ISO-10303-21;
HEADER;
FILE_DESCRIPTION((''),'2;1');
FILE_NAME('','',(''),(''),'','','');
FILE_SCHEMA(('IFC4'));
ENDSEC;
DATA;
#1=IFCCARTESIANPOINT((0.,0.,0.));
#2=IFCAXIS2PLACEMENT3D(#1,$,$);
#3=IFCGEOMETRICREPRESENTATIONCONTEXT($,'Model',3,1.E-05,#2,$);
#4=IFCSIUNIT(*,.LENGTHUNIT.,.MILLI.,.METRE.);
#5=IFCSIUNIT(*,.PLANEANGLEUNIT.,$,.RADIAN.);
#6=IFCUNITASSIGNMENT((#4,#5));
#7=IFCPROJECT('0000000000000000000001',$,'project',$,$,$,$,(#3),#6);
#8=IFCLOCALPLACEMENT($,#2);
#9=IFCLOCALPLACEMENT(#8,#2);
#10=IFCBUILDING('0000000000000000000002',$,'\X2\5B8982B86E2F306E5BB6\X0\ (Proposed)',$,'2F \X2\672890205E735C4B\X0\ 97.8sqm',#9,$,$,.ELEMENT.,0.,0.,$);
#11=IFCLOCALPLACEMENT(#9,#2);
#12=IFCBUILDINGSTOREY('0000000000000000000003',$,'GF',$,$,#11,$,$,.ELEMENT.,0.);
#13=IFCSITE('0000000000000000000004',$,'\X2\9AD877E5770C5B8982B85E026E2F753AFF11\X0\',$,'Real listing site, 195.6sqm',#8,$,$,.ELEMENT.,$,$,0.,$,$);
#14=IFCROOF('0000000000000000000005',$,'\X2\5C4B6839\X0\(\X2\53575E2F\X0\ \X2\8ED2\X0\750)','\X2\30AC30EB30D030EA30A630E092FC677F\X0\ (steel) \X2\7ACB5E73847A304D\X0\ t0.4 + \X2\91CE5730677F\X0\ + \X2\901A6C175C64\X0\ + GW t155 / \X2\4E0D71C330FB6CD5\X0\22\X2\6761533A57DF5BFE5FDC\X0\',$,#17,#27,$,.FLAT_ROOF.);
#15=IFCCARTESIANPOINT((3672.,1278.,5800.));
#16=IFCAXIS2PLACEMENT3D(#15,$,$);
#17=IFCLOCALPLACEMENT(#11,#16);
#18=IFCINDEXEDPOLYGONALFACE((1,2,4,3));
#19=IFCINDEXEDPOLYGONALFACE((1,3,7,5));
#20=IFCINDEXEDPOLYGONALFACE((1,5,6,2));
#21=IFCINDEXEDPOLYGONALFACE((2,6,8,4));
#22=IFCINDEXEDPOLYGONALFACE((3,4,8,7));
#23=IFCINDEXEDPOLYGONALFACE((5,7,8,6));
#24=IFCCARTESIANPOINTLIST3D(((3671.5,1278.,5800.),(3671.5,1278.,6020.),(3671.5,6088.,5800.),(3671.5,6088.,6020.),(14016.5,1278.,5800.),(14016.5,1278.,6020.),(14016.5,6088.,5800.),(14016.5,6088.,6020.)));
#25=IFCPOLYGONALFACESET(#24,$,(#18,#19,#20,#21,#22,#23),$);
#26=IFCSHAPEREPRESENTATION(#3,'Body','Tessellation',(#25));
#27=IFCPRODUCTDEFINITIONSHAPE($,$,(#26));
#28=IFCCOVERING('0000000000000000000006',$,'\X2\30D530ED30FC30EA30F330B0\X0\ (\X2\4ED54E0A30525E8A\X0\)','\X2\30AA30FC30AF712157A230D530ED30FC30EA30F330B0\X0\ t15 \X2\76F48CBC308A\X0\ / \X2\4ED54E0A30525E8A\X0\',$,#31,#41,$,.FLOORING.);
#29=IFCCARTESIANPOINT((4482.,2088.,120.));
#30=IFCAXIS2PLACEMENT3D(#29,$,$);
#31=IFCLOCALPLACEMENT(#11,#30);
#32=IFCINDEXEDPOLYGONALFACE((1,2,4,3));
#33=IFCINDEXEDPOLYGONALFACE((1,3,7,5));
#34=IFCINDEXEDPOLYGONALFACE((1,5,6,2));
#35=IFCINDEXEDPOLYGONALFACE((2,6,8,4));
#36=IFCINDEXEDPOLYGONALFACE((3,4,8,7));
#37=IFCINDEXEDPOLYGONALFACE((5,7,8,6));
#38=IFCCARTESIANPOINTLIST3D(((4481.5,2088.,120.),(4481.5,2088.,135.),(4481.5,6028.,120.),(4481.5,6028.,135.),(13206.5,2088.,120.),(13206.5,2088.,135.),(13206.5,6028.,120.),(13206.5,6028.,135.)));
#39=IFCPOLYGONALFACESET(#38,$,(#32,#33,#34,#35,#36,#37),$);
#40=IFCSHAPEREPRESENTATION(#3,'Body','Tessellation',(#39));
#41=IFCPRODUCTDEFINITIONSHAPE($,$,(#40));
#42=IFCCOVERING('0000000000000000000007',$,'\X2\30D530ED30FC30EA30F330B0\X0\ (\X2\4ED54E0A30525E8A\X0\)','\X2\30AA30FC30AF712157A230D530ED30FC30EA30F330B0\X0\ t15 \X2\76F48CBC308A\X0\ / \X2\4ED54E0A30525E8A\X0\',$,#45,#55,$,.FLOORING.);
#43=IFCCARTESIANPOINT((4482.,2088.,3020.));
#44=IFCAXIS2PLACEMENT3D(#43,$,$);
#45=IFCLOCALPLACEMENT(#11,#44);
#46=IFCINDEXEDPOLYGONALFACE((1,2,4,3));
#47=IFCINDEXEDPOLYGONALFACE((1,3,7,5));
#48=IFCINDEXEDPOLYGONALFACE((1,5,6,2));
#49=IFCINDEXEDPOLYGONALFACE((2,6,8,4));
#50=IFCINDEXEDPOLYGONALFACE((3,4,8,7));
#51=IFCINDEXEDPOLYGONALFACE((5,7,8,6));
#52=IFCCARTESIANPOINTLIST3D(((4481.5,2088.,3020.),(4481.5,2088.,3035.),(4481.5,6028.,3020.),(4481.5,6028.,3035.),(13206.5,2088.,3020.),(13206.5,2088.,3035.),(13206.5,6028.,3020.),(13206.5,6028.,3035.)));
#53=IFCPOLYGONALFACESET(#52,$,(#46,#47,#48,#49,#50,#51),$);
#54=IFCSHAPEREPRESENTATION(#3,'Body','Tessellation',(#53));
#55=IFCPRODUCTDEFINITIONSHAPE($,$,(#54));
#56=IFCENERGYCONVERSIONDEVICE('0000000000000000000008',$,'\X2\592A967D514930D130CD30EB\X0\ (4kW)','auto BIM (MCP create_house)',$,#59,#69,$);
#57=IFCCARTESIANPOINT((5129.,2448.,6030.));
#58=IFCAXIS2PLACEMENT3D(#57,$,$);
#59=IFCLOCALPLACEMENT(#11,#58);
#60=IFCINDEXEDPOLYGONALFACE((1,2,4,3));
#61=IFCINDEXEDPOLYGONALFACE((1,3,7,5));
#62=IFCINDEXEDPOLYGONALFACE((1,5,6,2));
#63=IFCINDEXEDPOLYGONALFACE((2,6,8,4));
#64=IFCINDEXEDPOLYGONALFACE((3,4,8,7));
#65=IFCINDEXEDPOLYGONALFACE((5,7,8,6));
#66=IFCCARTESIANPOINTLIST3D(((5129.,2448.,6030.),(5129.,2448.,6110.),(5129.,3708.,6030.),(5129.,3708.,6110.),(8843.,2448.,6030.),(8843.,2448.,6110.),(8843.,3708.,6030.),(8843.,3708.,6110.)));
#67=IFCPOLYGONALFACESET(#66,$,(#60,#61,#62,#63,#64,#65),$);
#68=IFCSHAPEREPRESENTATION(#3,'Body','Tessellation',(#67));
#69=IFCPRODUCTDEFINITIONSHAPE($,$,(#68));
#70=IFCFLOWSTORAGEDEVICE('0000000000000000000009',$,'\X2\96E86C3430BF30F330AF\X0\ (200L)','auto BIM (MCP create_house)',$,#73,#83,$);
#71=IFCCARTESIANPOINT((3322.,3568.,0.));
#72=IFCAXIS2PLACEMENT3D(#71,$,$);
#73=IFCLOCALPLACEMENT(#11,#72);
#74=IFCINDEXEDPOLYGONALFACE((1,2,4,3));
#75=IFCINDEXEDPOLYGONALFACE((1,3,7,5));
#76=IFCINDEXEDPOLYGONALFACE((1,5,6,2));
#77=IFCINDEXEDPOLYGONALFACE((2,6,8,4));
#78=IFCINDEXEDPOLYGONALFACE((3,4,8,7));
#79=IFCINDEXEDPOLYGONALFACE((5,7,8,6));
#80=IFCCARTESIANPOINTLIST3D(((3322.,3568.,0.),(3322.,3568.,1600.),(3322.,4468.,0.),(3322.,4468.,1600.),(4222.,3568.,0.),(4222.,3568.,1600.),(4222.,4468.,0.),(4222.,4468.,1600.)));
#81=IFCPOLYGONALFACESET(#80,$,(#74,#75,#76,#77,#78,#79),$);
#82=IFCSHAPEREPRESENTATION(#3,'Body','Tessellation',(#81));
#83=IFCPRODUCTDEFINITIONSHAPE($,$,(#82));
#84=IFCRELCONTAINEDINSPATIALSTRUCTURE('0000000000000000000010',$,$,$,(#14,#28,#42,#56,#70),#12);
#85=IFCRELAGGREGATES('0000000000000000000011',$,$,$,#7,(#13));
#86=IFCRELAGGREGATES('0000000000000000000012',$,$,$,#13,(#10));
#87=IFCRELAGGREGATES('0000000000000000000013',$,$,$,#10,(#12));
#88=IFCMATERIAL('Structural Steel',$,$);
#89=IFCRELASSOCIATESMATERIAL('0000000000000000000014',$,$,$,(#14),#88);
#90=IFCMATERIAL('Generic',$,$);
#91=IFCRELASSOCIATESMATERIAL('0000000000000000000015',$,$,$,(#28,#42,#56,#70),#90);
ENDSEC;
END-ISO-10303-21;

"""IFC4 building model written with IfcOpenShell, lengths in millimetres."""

from ifc_helpers import new_model, si_unit, frame, frame_2d, origin, place, context, project, spatial, rectangle, extrude, material, element, save


model = new_model("IFC4")

# Units and contexts
model_context = context("Model", 3, precision=1e-05, world=origin())
ifc_project = project(units=[si_unit("LENGTHUNIT", "METRE", prefix="MILLI"), si_unit("PLANEANGLEUNIT", "RADIAN")], contexts=[model_context])

# Site, building, storey
site_placement = place(None, origin())
site = spatial("IfcSite", under=ifc_project, at=site_placement, Name="高知県安芸市港町１", ObjectType="Real listing site, 195.6sqm", CompositionType="ELEMENT", RefElevation=0.0)
building_placement = place(site_placement, origin())
building = spatial("IfcBuilding", under=site, at=building_placement, Name="安芸港の家 (Proposed)", ObjectType="2F 木造平屋 97.8sqm", CompositionType="ELEMENT", ElevationOfRefHeight=0.0, ElevationOfTerrain=0.0)
storey_placement = place(building_placement, origin())
storey = spatial("IfcBuildingStorey", under=building, at=storey_placement, Name="GF", CompositionType="ELEMENT", Elevation=0.0)

# Roof
ifc_material_1 = material(Name="Structural Steel")
for number, where, name in (
    (1, (3672.0, 1278.0, 5800.0), "屋根(南帯 軒750)"),
):
    element("IfcRoof", number, at=place(storey_placement, frame(where)), inside=storey, material=ifc_material_1, Name=name, Description="ガルバリウム鋼板 (steel) 立平葺き t0.4 + 野地板 + 通気層 + GW t155 / 不燃・法22条区域対応", PredefinedType="FLAT_ROOF", context=model_context, shape_type="SweptSolid", body=[
        extrude(rectangle(XDim=10345.0, YDim=4810.0, at=frame_2d((5172.0, 2405.0))), frame((3672.0, 1278.0, 5800.0)), (0.0, 0.0, 1.0), 220.0),
    ])

# Coverings
ifc_material_2 = material(Name="Generic")
covering_1_placement = place(storey_placement, frame((4482.0, 2088.0, 120.0)))
element("IfcCovering", 2, at=covering_1_placement, inside=storey, material=ifc_material_2, Name="フローリング (仕上げ床)", Description="オーク無垢フローリング t15 直貼り / 仕上げ床", PredefinedType="FLOORING", context=model_context, shape_type="SweptSolid", body=[
    extrude(rectangle(XDim=8725.0, YDim=3940.0, at=frame_2d((4362.0, 1970.0))), frame((4482.0, 2088.0, 120.0)), (0.0, 0.0, 1.0), 15.0),
])
covering_2_placement = place(storey_placement, frame((4482.0, 2088.0, 3020.0)))
element("IfcCovering", 3, at=covering_2_placement, inside=storey, material=ifc_material_2, Name="フローリング (仕上げ床)", Description="オーク無垢フローリング t15 直貼り / 仕上げ床", PredefinedType="FLOORING", context=model_context, shape_type="SweptSolid", body=[
    extrude(rectangle(XDim=8725.0, YDim=3940.0, at=frame_2d((4362.0, 1970.0))), frame((4482.0, 2088.0, 3020.0)), (0.0, 0.0, 1.0), 15.0),
])

# Energy conversion device
energy_conversion_device_placement = place(storey_placement, frame((5129.0, 2448.0, 6030.0)))
element("IfcEnergyConversionDevice", 4, at=energy_conversion_device_placement, inside=storey, material=ifc_material_2, Name="太陽光パネル (4kW)", Description="auto BIM (MCP create_house)", context=model_context, shape_type="SweptSolid", body=[
    extrude(rectangle(XDim=3714.0, YDim=1260.0, at=frame_2d((1857.0, 630.0))), frame((5129.0, 2448.0, 6030.0)), (0.0, 0.0, 1.0), 80.0),
])

# Flow storage device
flow_storage_device_placement = place(storey_placement, frame((3322.0, 3568.0, 0.0)))
element("IfcFlowStorageDevice", 5, at=flow_storage_device_placement, inside=storey, material=ifc_material_2, Name="雨水タンク (200L)", Description="auto BIM (MCP create_house)", context=model_context, shape_type="SweptSolid", body=[
    extrude(rectangle(XDim=900.0, YDim=900.0, at=frame_2d((450.0, 450.0))), frame((3322.0, 3568.0, 0.0)), (0.0, 0.0, 1.0), 1600.0),
])

save(model, "model.ifc")
